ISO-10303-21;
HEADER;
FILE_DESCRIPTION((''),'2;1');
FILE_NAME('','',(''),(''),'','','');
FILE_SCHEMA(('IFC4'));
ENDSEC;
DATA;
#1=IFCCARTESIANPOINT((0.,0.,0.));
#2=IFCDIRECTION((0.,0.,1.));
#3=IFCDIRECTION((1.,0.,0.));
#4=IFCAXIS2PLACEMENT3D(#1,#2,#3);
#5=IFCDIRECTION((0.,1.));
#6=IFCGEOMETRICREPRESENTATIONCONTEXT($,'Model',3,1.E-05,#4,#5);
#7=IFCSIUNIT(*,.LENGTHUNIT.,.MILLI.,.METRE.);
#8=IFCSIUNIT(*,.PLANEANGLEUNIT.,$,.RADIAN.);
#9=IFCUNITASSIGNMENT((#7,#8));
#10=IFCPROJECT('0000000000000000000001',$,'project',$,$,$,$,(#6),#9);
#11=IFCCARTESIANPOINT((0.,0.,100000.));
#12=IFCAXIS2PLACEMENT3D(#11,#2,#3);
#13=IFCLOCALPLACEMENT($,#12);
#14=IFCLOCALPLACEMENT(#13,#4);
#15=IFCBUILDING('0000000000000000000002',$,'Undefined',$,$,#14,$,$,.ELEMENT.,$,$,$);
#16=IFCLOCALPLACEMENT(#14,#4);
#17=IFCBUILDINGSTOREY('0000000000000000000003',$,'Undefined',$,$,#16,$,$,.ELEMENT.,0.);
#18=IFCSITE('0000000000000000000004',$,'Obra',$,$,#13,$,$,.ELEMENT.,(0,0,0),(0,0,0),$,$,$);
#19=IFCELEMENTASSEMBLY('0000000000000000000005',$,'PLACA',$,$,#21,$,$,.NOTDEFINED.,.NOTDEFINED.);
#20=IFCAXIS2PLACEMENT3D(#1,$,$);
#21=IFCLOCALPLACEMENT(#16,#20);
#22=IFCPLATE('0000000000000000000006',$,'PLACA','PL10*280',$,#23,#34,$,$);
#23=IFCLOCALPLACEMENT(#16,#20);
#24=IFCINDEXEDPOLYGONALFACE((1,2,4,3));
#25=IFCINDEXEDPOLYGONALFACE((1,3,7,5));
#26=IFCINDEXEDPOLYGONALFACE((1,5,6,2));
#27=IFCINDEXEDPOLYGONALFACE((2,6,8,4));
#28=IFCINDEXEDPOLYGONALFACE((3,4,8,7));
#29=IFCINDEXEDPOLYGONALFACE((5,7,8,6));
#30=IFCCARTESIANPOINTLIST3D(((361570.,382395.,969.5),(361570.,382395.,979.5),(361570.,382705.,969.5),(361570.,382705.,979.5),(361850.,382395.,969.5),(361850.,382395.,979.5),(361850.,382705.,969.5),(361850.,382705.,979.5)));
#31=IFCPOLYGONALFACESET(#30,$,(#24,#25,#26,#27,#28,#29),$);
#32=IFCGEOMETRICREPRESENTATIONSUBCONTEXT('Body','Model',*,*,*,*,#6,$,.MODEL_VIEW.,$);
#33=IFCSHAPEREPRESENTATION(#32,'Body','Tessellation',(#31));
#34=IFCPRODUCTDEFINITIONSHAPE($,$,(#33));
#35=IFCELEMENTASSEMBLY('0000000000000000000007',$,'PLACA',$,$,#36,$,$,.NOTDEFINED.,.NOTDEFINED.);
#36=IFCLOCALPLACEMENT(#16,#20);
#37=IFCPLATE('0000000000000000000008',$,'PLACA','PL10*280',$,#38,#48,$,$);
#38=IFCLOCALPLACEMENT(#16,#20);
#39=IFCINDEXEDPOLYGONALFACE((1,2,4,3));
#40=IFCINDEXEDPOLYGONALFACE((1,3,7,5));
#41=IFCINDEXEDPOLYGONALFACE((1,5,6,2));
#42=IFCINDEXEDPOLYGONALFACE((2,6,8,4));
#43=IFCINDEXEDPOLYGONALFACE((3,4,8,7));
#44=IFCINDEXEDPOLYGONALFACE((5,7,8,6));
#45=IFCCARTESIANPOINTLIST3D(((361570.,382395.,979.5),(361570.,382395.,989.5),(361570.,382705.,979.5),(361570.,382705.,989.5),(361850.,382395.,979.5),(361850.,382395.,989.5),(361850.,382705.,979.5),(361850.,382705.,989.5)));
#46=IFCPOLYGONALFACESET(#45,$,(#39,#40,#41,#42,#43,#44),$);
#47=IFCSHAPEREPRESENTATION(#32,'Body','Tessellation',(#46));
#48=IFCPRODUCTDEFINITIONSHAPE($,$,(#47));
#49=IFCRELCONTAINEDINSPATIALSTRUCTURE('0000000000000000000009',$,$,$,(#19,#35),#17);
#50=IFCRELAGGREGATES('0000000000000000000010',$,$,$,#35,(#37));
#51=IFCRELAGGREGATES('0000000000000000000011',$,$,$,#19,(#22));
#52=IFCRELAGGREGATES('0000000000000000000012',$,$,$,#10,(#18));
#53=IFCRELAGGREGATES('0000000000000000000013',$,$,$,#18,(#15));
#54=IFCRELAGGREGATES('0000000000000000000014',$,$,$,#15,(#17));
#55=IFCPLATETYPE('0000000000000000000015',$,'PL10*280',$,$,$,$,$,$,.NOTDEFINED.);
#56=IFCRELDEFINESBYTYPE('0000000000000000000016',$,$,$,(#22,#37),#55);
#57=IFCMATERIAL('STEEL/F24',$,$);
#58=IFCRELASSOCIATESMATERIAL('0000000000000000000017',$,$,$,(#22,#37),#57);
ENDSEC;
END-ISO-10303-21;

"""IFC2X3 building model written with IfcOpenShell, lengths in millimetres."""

from ifc_helpers import new_model, si_unit, direction, frame, origin_with_axes, place, context, subcontext, project, spatial, polyline, outline, extrude, material, type_object, element, aggregate, save


model = new_model("IFC2X3")

# Units and contexts
model_context = context("Model", 3, precision=1e-05, world=origin_with_axes(), true_north=direction((0.0, 1.0)))
body_context = subcontext(model_context, "Body", "Model", "MODEL_VIEW")
ifc_project = project(units=[si_unit("LENGTHUNIT", "METRE", prefix="MILLI"), si_unit("PLANEANGLEUNIT", "RADIAN")], contexts=[model_context])

# Site, building, storey
site_placement = place(None, frame((0.0, 0.0, 100000.0), z_axis=(0.0, 0.0, 1.0), x_axis=(1.0, 0.0, 0.0)))
site = spatial("IfcSite", under=ifc_project, at=site_placement, Name="Obra", CompositionType="ELEMENT", RefLatitude=(0, 0, 0), RefLongitude=(0, 0, 0))
building_placement = place(site_placement, origin_with_axes())
building = spatial("IfcBuilding", under=site, at=building_placement, Name="Undefined", CompositionType="ELEMENT")
storey_placement = place(building_placement, origin_with_axes())
storey = spatial("IfcBuildingStorey", under=building, at=storey_placement, Name="Undefined", CompositionType="ELEMENT", Elevation=0.0)

# Shared definitions
ifc_material_1 = material(Name="STEEL/F24")

# Element assemblies, plates
plate_type_1 = type_object("IfcPlateType", Name="PL10*280", PredefinedType="NOTDEFINED")
assembly_1_placement = place(storey_placement, origin_with_axes())
assembly_1 = element("IfcElementAssembly", 1, at=assembly_1_placement, inside=storey, Name="PLACA", AssemblyPlace="NOTDEFINED", PredefinedType="NOTDEFINED")
plate_1_placement = place(assembly_1_placement, frame((361570.0, 382395.0, 974.5), z_axis=(0.0, 0.0, 1.0), x_axis=(1.0, 0.0, 0.0)))
plate_1 = element("IfcPlate", 2, at=plate_1_placement, type_object=plate_type_1, material=ifc_material_1, Name="PLACA", Description="PL10*280", context=body_context, shape_type="SweptSolid", body=[
    extrude(outline(polyline([(0.0, 0.0), (280.0, 0.0), (280.0, 310.0), (0.0, 310.0), (0.0, 0.0)])), frame((0.0, 0.0, -5.0), z_axis=(0.0, 0.0, 1.0), x_axis=(1.0, 0.0, 0.0)), (0.0, 0.0, 1.0), 10.0),
])
assembly_2_placement = place(storey_placement, origin_with_axes())
assembly_2 = element("IfcElementAssembly", 3, at=assembly_2_placement, inside=storey, Name="PLACA", AssemblyPlace="NOTDEFINED", PredefinedType="NOTDEFINED")
plate_2_placement = place(assembly_2_placement, frame((361570.0, 382395.0, 984.5), z_axis=(0.0, 0.0, 1.0), x_axis=(1.0, 0.0, 0.0)))
plate_2 = element("IfcPlate", 4, at=plate_2_placement, type_object=plate_type_1, material=ifc_material_1, Name="PLACA", Description="PL10*280", context=body_context, shape_type="SweptSolid", body=[
    extrude(outline(polyline([(0.0, 0.0), (280.0, 0.0), (280.0, 310.0), (0.0, 310.0), (0.0, 0.0)])), frame((0.0, 0.0, -5.0), z_axis=(0.0, 0.0, 1.0), x_axis=(1.0, 0.0, 0.0)), (0.0, 0.0, 1.0), 10.0),
])
aggregate(assembly_2, [plate_2])

aggregate(assembly_1, [plate_1])

save(model, "model.ifc")
